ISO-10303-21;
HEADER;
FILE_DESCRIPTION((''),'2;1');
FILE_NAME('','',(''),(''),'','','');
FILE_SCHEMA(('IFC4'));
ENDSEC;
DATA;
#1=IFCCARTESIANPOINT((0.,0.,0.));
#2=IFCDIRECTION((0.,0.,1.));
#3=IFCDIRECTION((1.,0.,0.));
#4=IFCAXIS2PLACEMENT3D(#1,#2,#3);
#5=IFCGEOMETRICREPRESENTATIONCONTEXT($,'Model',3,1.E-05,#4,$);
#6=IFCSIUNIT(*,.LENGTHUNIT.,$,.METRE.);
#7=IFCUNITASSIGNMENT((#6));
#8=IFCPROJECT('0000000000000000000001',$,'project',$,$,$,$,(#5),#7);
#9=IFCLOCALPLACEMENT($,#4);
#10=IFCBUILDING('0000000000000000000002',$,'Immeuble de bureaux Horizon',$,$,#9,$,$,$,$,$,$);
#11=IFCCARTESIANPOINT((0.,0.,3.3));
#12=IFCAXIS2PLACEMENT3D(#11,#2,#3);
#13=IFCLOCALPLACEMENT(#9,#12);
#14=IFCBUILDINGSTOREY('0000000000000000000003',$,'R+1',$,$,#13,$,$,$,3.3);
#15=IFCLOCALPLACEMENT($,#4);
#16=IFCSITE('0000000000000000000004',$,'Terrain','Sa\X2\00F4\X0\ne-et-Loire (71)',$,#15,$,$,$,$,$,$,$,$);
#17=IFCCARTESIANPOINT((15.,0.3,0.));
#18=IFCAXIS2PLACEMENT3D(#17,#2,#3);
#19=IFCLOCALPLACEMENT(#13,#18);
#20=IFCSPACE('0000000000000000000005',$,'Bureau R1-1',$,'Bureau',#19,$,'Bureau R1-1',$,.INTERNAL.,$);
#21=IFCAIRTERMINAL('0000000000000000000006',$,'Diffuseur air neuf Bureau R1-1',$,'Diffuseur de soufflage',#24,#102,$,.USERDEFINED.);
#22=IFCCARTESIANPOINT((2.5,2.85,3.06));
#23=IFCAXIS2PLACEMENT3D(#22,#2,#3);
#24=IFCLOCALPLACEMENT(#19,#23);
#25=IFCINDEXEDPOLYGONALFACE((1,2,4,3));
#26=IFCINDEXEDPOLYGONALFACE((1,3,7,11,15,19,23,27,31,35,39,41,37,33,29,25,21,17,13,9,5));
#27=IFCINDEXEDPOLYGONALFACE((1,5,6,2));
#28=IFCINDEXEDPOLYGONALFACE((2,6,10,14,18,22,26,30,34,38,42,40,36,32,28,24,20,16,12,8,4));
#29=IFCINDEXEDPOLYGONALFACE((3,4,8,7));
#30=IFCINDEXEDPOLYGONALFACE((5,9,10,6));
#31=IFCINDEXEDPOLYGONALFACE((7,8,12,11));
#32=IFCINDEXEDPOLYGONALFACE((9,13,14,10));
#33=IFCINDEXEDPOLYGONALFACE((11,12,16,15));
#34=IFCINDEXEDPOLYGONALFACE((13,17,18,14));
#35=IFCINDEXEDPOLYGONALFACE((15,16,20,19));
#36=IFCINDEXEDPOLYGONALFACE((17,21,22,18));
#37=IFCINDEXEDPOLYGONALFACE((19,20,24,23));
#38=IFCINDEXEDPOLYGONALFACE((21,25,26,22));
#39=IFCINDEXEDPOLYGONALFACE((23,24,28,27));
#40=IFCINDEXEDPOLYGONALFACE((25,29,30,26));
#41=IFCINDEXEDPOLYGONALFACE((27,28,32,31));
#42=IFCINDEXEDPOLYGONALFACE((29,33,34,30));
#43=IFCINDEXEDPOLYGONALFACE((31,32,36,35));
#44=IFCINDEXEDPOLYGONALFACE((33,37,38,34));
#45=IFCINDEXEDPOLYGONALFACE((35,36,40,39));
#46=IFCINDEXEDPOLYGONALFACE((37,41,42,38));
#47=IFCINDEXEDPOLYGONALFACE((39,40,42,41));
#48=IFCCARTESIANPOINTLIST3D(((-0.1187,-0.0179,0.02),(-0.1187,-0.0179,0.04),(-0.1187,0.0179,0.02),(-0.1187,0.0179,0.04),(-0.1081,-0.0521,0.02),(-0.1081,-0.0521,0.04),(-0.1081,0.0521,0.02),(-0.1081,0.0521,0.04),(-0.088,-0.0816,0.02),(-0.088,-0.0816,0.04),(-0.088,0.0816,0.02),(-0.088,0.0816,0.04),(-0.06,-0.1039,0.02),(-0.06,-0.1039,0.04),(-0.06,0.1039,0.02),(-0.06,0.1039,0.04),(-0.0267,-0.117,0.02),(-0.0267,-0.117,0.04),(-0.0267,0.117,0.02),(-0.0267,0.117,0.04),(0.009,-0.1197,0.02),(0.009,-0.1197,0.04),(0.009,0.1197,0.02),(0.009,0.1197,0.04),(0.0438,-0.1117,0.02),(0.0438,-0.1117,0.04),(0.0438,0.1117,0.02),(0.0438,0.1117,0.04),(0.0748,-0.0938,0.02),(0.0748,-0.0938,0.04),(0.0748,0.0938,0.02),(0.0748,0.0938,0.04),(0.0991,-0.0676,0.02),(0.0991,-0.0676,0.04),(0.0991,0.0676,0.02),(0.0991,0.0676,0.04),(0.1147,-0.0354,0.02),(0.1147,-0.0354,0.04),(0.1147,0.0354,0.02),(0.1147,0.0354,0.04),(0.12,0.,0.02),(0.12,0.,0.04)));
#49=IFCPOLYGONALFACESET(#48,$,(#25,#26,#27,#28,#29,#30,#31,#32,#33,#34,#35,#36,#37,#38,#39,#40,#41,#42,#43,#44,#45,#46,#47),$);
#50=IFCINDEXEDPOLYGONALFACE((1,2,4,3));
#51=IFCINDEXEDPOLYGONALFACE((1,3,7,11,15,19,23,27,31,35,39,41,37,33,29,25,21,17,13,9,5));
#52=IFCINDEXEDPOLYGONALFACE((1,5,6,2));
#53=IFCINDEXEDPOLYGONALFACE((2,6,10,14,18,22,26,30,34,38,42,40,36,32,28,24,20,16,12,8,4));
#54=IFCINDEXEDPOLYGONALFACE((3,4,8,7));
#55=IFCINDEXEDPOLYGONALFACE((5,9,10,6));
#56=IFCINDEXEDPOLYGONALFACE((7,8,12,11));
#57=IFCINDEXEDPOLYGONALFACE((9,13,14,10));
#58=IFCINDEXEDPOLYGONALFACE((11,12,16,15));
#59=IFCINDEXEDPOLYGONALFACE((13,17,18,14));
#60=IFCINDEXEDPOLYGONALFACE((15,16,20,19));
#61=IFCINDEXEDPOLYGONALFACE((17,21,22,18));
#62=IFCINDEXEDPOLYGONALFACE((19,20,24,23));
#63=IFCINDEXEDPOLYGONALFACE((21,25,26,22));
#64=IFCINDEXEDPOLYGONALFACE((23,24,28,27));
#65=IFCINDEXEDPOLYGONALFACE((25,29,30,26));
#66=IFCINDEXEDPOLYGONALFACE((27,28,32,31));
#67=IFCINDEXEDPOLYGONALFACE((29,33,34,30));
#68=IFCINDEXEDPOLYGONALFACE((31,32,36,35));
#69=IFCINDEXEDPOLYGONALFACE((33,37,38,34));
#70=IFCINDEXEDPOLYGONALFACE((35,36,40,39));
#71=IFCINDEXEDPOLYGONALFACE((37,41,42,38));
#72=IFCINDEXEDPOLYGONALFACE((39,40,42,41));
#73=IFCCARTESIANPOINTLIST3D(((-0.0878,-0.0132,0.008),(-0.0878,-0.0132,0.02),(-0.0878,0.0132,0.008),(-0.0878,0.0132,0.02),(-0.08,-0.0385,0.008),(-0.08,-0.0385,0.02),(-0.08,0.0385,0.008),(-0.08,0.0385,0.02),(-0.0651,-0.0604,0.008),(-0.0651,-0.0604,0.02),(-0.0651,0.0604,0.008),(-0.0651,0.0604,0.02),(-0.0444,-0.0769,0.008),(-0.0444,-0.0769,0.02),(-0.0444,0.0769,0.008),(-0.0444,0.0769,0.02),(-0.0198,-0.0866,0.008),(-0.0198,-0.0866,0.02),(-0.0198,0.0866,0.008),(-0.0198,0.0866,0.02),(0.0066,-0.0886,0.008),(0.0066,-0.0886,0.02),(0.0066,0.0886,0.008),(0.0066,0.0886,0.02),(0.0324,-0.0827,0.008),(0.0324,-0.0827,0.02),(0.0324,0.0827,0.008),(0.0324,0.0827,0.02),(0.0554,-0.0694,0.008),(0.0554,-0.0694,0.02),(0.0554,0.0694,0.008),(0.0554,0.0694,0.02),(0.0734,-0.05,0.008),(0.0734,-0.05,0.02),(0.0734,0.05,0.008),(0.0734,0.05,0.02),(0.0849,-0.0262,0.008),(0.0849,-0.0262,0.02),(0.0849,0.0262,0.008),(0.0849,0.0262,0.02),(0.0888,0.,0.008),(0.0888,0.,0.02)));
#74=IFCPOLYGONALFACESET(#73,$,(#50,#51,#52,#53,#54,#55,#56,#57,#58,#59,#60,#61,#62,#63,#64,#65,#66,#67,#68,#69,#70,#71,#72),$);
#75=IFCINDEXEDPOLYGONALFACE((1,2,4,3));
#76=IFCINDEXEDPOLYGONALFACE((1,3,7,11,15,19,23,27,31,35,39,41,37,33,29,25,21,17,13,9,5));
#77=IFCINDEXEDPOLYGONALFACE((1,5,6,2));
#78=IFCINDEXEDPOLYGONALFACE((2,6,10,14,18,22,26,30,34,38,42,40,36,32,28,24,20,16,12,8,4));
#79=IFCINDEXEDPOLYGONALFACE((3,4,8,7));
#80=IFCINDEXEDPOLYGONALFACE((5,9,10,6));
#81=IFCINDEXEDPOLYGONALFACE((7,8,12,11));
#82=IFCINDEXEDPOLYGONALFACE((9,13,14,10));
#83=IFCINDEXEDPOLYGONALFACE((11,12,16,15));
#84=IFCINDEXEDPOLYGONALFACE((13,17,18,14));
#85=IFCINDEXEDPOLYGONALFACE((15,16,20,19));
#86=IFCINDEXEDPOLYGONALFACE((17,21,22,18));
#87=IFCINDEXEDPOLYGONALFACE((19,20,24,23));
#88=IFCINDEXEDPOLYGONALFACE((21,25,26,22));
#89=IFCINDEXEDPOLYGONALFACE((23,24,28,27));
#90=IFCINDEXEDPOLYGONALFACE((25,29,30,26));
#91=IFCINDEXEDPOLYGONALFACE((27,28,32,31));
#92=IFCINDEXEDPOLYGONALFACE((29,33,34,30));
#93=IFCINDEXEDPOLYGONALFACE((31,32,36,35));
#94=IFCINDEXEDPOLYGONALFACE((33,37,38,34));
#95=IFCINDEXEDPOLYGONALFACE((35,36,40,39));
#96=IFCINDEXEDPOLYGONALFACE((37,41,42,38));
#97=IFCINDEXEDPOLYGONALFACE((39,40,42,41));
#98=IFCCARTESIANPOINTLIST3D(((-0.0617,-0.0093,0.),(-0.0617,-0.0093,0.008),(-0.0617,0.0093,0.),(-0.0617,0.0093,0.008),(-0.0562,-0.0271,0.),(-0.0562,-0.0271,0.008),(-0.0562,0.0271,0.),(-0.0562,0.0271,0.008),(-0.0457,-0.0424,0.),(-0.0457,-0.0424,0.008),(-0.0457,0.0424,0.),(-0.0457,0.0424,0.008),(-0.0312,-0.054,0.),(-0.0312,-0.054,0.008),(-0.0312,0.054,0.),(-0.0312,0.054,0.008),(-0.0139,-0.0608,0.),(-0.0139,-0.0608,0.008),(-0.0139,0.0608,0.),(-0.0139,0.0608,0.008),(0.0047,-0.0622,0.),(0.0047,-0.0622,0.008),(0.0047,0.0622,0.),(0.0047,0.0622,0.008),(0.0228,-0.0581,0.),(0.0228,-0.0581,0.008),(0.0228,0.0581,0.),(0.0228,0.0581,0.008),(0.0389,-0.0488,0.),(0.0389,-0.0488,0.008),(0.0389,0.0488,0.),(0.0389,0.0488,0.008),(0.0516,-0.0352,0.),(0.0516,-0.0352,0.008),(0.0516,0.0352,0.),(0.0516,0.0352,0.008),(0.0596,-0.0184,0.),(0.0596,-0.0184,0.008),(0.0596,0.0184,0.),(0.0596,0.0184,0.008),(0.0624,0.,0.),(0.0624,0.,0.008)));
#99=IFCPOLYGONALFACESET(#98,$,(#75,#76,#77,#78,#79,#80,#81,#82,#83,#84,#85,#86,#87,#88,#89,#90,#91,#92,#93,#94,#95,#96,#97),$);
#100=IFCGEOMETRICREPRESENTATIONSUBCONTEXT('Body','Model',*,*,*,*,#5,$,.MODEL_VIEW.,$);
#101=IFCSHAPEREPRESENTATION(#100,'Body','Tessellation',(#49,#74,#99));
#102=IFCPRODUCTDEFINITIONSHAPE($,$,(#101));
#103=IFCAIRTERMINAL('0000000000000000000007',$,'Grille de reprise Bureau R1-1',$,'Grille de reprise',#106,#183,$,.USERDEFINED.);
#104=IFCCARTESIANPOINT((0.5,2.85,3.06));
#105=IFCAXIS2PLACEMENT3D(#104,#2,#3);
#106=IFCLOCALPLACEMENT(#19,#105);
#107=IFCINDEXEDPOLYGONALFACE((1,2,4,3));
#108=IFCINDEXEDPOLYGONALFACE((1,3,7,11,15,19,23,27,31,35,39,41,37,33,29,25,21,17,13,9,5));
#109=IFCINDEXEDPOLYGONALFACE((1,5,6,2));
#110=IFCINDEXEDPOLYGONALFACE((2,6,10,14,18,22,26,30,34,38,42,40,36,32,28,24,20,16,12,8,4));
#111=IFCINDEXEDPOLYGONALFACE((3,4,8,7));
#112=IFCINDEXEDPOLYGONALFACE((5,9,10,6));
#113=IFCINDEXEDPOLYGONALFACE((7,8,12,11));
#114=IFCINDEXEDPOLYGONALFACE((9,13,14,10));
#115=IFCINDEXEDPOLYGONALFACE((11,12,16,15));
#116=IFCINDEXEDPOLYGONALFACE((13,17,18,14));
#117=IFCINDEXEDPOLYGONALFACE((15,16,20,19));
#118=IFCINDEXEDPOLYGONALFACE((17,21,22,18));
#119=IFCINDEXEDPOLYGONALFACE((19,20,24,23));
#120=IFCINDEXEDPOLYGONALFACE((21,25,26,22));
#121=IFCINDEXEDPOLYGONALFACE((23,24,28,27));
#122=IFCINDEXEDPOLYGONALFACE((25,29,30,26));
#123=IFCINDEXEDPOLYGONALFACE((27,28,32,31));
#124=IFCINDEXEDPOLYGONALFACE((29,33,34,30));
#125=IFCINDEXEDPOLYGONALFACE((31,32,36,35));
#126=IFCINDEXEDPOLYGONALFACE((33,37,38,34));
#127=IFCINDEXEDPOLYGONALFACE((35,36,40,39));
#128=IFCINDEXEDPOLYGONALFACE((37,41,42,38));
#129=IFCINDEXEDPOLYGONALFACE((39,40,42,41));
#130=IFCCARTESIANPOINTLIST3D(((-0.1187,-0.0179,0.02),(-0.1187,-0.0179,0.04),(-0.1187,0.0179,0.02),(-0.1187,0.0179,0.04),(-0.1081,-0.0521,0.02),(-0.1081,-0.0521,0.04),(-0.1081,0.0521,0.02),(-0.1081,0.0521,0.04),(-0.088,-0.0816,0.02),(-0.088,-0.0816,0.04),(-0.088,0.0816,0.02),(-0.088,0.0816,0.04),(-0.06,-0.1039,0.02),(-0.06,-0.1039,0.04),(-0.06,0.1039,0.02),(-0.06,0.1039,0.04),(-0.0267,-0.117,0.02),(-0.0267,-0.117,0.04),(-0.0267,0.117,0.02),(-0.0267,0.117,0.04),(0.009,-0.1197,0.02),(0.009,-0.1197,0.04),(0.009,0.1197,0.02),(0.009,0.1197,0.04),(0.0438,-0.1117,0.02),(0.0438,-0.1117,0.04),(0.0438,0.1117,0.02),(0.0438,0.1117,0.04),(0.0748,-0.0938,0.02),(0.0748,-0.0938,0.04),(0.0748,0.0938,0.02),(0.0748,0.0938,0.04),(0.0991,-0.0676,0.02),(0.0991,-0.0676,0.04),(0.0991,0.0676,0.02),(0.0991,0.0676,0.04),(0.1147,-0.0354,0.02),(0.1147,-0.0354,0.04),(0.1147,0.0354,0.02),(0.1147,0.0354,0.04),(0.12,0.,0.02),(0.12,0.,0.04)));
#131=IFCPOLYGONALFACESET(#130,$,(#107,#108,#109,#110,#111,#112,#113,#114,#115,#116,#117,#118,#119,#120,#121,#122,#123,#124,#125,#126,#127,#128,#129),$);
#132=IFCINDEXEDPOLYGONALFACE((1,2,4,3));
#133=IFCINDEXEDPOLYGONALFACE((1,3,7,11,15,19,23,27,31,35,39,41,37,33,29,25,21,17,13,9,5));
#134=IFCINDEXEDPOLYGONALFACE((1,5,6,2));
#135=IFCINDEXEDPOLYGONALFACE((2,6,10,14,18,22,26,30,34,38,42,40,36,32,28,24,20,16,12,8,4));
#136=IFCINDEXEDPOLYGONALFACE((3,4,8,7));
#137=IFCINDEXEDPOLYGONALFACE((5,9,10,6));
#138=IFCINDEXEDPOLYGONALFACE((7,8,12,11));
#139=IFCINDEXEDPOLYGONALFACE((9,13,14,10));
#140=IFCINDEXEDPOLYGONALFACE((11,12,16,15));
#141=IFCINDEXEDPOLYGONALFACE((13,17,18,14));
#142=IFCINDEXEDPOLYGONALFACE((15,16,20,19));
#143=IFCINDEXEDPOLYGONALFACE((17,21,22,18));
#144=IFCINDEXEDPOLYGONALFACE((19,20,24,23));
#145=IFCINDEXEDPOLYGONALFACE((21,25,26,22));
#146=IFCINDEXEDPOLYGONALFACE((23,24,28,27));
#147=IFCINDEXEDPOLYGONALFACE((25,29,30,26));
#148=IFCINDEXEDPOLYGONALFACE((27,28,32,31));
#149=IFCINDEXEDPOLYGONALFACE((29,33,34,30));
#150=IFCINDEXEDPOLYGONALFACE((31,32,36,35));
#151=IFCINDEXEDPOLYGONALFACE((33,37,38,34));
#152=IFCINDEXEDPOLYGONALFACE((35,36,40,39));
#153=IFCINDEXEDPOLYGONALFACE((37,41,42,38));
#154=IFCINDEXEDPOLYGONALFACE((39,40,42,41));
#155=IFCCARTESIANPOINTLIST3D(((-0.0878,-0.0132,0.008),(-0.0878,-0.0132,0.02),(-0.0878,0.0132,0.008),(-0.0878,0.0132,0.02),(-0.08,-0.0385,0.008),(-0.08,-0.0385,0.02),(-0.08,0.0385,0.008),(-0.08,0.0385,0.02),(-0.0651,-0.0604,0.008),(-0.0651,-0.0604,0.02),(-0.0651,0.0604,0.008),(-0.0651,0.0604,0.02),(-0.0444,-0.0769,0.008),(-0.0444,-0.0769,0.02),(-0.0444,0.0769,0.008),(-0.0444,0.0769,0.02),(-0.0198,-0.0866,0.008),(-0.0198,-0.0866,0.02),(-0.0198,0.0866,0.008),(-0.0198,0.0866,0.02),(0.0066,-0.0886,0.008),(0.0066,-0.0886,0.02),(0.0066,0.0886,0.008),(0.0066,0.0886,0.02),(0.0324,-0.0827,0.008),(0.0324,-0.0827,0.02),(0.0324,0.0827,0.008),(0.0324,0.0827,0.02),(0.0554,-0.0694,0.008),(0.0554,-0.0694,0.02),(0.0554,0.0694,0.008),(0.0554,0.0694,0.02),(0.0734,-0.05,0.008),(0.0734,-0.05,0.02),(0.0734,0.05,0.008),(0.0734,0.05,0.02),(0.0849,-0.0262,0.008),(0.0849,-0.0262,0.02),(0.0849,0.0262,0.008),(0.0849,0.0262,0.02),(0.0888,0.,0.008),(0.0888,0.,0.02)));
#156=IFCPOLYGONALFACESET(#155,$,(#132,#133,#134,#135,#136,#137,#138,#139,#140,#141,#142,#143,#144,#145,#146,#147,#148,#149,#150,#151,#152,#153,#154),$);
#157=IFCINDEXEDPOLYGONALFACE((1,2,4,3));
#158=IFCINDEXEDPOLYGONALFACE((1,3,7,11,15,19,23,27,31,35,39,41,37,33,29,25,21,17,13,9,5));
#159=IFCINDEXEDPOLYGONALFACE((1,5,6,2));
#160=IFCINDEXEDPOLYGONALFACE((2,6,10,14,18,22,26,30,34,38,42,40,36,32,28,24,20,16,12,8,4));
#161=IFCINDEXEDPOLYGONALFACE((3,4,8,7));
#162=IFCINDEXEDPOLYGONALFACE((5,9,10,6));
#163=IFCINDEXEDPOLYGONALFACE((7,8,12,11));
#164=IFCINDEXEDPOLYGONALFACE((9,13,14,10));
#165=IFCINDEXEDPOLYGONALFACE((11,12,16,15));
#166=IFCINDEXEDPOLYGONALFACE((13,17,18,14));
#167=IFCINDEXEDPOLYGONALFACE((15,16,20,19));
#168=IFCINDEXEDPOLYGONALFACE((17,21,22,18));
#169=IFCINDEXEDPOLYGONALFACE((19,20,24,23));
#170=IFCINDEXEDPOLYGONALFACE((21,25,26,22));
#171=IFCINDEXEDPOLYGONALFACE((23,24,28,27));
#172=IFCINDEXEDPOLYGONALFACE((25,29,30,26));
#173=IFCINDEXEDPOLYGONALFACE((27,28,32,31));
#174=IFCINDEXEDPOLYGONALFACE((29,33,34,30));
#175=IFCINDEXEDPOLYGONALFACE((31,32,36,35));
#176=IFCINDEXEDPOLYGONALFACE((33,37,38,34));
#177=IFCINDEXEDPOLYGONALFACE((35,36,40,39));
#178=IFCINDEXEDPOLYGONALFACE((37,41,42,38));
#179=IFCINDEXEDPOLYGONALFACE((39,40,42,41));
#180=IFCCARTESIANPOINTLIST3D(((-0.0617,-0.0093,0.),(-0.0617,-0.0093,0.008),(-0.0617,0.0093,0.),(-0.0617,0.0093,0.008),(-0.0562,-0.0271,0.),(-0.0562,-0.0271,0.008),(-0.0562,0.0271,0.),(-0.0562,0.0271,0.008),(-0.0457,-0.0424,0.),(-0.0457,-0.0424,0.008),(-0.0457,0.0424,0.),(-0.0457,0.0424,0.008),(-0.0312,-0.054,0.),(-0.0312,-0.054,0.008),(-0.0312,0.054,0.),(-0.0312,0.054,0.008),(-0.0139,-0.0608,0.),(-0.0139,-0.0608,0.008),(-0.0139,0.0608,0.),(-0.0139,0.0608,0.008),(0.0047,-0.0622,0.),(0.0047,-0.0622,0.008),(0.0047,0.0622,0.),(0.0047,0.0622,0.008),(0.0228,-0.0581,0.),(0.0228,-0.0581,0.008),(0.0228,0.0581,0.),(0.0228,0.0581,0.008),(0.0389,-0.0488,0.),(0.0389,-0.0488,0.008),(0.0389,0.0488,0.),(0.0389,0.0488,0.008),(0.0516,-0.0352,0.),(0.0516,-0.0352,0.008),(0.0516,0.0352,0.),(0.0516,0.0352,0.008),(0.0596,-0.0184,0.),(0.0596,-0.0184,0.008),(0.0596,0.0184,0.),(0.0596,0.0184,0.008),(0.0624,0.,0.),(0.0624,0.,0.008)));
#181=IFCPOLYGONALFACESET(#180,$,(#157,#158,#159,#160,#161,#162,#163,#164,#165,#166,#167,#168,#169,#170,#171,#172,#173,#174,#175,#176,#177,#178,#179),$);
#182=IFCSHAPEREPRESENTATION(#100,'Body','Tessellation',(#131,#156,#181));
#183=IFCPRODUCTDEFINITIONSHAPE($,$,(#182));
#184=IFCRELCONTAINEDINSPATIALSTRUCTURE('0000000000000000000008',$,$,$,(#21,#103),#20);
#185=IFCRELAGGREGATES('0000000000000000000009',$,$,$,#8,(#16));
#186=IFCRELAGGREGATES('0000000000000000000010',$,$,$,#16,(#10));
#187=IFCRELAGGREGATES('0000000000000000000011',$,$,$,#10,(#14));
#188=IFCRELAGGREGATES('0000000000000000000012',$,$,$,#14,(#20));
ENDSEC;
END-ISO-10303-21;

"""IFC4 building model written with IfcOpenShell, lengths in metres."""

from ifc_helpers import new_model, si_unit, frame, origin_with_axes, place, context, subcontext, project, spatial, circle, extrude, element, save


model = new_model("IFC4")

# Units and contexts
model_context = context("Model", 3, precision=1e-05, world=origin_with_axes())
body_context = subcontext(model_context, "Body", "Model", "MODEL_VIEW")
ifc_project = project(units=[si_unit("LENGTHUNIT", "METRE")], contexts=[model_context])

# Site, building, storey
site_placement = place(None, origin_with_axes())
site = spatial("IfcSite", under=ifc_project, at=site_placement, Name="Terrain", Description="Saône-et-Loire (71)")
building_placement = place(None, origin_with_axes())
building = spatial("IfcBuilding", under=site, at=building_placement, Name="Immeuble de bureaux Horizon")
storey_placement = place(building_placement, frame((0.0, 0.0, 3.3), z_axis=(0.0, 0.0, 1.0), x_axis=(1.0, 0.0, 0.0)))
storey = spatial("IfcBuildingStorey", under=building, at=storey_placement, Name="R+1", Elevation=3.3)

# Shared definitions
space_1_placement = place(storey_placement, frame((15.0, 0.3, 0.0), z_axis=(0.0, 0.0, 1.0), x_axis=(1.0, 0.0, 0.0)))
space_1 = spatial("IfcSpace", under=storey, at=space_1_placement, Name="Bureau R1-1", ObjectType="Bureau", LongName="Bureau R1-1", PredefinedType="INTERNAL")

# Air terminal
air_terminal_1_placement = place(space_1_placement, frame((2.5, 2.85, 3.06), z_axis=(0.0, 0.0, 1.0), x_axis=(1.0, 0.0, 0.0)))
element("IfcAirTerminal", 1, at=air_terminal_1_placement, inside=space_1, Name="Diffuseur air neuf Bureau R1-1", ObjectType="Diffuseur de soufflage", PredefinedType="USERDEFINED", context=body_context, shape_type="SweptSolid", body=[
    extrude(circle(Radius=0.12), frame((0.0, 0.0, 0.02), z_axis=(0.0, 0.0, 1.0), x_axis=(1.0, 0.0, 0.0)), (0.0, 0.0, 1.0), 0.02),
    extrude(circle(Radius=0.0888), frame((0.0, 0.0, 0.008), z_axis=(0.0, 0.0, 1.0), x_axis=(1.0, 0.0, 0.0)), (0.0, 0.0, 1.0), 0.012),
    extrude(circle(Radius=0.0624), origin_with_axes(), (0.0, 0.0, 1.0), 0.008),
])

# Air terminal
air_terminal_2_placement = place(space_1_placement, frame((0.5, 2.85, 3.06), z_axis=(0.0, 0.0, 1.0), x_axis=(1.0, 0.0, 0.0)))
element("IfcAirTerminal", 2, at=air_terminal_2_placement, inside=space_1, Name="Grille de reprise Bureau R1-1", ObjectType="Grille de reprise", PredefinedType="USERDEFINED", context=body_context, shape_type="SweptSolid", body=[
    extrude(circle(Radius=0.12), frame((0.0, 0.0, 0.02), z_axis=(0.0, 0.0, 1.0), x_axis=(1.0, 0.0, 0.0)), (0.0, 0.0, 1.0), 0.02),
    extrude(circle(Radius=0.0888), frame((0.0, 0.0, 0.008), z_axis=(0.0, 0.0, 1.0), x_axis=(1.0, 0.0, 0.0)), (0.0, 0.0, 1.0), 0.012),
    extrude(circle(Radius=0.0624), origin_with_axes(), (0.0, 0.0, 1.0), 0.008),
])

save(model, "model.ifc")
